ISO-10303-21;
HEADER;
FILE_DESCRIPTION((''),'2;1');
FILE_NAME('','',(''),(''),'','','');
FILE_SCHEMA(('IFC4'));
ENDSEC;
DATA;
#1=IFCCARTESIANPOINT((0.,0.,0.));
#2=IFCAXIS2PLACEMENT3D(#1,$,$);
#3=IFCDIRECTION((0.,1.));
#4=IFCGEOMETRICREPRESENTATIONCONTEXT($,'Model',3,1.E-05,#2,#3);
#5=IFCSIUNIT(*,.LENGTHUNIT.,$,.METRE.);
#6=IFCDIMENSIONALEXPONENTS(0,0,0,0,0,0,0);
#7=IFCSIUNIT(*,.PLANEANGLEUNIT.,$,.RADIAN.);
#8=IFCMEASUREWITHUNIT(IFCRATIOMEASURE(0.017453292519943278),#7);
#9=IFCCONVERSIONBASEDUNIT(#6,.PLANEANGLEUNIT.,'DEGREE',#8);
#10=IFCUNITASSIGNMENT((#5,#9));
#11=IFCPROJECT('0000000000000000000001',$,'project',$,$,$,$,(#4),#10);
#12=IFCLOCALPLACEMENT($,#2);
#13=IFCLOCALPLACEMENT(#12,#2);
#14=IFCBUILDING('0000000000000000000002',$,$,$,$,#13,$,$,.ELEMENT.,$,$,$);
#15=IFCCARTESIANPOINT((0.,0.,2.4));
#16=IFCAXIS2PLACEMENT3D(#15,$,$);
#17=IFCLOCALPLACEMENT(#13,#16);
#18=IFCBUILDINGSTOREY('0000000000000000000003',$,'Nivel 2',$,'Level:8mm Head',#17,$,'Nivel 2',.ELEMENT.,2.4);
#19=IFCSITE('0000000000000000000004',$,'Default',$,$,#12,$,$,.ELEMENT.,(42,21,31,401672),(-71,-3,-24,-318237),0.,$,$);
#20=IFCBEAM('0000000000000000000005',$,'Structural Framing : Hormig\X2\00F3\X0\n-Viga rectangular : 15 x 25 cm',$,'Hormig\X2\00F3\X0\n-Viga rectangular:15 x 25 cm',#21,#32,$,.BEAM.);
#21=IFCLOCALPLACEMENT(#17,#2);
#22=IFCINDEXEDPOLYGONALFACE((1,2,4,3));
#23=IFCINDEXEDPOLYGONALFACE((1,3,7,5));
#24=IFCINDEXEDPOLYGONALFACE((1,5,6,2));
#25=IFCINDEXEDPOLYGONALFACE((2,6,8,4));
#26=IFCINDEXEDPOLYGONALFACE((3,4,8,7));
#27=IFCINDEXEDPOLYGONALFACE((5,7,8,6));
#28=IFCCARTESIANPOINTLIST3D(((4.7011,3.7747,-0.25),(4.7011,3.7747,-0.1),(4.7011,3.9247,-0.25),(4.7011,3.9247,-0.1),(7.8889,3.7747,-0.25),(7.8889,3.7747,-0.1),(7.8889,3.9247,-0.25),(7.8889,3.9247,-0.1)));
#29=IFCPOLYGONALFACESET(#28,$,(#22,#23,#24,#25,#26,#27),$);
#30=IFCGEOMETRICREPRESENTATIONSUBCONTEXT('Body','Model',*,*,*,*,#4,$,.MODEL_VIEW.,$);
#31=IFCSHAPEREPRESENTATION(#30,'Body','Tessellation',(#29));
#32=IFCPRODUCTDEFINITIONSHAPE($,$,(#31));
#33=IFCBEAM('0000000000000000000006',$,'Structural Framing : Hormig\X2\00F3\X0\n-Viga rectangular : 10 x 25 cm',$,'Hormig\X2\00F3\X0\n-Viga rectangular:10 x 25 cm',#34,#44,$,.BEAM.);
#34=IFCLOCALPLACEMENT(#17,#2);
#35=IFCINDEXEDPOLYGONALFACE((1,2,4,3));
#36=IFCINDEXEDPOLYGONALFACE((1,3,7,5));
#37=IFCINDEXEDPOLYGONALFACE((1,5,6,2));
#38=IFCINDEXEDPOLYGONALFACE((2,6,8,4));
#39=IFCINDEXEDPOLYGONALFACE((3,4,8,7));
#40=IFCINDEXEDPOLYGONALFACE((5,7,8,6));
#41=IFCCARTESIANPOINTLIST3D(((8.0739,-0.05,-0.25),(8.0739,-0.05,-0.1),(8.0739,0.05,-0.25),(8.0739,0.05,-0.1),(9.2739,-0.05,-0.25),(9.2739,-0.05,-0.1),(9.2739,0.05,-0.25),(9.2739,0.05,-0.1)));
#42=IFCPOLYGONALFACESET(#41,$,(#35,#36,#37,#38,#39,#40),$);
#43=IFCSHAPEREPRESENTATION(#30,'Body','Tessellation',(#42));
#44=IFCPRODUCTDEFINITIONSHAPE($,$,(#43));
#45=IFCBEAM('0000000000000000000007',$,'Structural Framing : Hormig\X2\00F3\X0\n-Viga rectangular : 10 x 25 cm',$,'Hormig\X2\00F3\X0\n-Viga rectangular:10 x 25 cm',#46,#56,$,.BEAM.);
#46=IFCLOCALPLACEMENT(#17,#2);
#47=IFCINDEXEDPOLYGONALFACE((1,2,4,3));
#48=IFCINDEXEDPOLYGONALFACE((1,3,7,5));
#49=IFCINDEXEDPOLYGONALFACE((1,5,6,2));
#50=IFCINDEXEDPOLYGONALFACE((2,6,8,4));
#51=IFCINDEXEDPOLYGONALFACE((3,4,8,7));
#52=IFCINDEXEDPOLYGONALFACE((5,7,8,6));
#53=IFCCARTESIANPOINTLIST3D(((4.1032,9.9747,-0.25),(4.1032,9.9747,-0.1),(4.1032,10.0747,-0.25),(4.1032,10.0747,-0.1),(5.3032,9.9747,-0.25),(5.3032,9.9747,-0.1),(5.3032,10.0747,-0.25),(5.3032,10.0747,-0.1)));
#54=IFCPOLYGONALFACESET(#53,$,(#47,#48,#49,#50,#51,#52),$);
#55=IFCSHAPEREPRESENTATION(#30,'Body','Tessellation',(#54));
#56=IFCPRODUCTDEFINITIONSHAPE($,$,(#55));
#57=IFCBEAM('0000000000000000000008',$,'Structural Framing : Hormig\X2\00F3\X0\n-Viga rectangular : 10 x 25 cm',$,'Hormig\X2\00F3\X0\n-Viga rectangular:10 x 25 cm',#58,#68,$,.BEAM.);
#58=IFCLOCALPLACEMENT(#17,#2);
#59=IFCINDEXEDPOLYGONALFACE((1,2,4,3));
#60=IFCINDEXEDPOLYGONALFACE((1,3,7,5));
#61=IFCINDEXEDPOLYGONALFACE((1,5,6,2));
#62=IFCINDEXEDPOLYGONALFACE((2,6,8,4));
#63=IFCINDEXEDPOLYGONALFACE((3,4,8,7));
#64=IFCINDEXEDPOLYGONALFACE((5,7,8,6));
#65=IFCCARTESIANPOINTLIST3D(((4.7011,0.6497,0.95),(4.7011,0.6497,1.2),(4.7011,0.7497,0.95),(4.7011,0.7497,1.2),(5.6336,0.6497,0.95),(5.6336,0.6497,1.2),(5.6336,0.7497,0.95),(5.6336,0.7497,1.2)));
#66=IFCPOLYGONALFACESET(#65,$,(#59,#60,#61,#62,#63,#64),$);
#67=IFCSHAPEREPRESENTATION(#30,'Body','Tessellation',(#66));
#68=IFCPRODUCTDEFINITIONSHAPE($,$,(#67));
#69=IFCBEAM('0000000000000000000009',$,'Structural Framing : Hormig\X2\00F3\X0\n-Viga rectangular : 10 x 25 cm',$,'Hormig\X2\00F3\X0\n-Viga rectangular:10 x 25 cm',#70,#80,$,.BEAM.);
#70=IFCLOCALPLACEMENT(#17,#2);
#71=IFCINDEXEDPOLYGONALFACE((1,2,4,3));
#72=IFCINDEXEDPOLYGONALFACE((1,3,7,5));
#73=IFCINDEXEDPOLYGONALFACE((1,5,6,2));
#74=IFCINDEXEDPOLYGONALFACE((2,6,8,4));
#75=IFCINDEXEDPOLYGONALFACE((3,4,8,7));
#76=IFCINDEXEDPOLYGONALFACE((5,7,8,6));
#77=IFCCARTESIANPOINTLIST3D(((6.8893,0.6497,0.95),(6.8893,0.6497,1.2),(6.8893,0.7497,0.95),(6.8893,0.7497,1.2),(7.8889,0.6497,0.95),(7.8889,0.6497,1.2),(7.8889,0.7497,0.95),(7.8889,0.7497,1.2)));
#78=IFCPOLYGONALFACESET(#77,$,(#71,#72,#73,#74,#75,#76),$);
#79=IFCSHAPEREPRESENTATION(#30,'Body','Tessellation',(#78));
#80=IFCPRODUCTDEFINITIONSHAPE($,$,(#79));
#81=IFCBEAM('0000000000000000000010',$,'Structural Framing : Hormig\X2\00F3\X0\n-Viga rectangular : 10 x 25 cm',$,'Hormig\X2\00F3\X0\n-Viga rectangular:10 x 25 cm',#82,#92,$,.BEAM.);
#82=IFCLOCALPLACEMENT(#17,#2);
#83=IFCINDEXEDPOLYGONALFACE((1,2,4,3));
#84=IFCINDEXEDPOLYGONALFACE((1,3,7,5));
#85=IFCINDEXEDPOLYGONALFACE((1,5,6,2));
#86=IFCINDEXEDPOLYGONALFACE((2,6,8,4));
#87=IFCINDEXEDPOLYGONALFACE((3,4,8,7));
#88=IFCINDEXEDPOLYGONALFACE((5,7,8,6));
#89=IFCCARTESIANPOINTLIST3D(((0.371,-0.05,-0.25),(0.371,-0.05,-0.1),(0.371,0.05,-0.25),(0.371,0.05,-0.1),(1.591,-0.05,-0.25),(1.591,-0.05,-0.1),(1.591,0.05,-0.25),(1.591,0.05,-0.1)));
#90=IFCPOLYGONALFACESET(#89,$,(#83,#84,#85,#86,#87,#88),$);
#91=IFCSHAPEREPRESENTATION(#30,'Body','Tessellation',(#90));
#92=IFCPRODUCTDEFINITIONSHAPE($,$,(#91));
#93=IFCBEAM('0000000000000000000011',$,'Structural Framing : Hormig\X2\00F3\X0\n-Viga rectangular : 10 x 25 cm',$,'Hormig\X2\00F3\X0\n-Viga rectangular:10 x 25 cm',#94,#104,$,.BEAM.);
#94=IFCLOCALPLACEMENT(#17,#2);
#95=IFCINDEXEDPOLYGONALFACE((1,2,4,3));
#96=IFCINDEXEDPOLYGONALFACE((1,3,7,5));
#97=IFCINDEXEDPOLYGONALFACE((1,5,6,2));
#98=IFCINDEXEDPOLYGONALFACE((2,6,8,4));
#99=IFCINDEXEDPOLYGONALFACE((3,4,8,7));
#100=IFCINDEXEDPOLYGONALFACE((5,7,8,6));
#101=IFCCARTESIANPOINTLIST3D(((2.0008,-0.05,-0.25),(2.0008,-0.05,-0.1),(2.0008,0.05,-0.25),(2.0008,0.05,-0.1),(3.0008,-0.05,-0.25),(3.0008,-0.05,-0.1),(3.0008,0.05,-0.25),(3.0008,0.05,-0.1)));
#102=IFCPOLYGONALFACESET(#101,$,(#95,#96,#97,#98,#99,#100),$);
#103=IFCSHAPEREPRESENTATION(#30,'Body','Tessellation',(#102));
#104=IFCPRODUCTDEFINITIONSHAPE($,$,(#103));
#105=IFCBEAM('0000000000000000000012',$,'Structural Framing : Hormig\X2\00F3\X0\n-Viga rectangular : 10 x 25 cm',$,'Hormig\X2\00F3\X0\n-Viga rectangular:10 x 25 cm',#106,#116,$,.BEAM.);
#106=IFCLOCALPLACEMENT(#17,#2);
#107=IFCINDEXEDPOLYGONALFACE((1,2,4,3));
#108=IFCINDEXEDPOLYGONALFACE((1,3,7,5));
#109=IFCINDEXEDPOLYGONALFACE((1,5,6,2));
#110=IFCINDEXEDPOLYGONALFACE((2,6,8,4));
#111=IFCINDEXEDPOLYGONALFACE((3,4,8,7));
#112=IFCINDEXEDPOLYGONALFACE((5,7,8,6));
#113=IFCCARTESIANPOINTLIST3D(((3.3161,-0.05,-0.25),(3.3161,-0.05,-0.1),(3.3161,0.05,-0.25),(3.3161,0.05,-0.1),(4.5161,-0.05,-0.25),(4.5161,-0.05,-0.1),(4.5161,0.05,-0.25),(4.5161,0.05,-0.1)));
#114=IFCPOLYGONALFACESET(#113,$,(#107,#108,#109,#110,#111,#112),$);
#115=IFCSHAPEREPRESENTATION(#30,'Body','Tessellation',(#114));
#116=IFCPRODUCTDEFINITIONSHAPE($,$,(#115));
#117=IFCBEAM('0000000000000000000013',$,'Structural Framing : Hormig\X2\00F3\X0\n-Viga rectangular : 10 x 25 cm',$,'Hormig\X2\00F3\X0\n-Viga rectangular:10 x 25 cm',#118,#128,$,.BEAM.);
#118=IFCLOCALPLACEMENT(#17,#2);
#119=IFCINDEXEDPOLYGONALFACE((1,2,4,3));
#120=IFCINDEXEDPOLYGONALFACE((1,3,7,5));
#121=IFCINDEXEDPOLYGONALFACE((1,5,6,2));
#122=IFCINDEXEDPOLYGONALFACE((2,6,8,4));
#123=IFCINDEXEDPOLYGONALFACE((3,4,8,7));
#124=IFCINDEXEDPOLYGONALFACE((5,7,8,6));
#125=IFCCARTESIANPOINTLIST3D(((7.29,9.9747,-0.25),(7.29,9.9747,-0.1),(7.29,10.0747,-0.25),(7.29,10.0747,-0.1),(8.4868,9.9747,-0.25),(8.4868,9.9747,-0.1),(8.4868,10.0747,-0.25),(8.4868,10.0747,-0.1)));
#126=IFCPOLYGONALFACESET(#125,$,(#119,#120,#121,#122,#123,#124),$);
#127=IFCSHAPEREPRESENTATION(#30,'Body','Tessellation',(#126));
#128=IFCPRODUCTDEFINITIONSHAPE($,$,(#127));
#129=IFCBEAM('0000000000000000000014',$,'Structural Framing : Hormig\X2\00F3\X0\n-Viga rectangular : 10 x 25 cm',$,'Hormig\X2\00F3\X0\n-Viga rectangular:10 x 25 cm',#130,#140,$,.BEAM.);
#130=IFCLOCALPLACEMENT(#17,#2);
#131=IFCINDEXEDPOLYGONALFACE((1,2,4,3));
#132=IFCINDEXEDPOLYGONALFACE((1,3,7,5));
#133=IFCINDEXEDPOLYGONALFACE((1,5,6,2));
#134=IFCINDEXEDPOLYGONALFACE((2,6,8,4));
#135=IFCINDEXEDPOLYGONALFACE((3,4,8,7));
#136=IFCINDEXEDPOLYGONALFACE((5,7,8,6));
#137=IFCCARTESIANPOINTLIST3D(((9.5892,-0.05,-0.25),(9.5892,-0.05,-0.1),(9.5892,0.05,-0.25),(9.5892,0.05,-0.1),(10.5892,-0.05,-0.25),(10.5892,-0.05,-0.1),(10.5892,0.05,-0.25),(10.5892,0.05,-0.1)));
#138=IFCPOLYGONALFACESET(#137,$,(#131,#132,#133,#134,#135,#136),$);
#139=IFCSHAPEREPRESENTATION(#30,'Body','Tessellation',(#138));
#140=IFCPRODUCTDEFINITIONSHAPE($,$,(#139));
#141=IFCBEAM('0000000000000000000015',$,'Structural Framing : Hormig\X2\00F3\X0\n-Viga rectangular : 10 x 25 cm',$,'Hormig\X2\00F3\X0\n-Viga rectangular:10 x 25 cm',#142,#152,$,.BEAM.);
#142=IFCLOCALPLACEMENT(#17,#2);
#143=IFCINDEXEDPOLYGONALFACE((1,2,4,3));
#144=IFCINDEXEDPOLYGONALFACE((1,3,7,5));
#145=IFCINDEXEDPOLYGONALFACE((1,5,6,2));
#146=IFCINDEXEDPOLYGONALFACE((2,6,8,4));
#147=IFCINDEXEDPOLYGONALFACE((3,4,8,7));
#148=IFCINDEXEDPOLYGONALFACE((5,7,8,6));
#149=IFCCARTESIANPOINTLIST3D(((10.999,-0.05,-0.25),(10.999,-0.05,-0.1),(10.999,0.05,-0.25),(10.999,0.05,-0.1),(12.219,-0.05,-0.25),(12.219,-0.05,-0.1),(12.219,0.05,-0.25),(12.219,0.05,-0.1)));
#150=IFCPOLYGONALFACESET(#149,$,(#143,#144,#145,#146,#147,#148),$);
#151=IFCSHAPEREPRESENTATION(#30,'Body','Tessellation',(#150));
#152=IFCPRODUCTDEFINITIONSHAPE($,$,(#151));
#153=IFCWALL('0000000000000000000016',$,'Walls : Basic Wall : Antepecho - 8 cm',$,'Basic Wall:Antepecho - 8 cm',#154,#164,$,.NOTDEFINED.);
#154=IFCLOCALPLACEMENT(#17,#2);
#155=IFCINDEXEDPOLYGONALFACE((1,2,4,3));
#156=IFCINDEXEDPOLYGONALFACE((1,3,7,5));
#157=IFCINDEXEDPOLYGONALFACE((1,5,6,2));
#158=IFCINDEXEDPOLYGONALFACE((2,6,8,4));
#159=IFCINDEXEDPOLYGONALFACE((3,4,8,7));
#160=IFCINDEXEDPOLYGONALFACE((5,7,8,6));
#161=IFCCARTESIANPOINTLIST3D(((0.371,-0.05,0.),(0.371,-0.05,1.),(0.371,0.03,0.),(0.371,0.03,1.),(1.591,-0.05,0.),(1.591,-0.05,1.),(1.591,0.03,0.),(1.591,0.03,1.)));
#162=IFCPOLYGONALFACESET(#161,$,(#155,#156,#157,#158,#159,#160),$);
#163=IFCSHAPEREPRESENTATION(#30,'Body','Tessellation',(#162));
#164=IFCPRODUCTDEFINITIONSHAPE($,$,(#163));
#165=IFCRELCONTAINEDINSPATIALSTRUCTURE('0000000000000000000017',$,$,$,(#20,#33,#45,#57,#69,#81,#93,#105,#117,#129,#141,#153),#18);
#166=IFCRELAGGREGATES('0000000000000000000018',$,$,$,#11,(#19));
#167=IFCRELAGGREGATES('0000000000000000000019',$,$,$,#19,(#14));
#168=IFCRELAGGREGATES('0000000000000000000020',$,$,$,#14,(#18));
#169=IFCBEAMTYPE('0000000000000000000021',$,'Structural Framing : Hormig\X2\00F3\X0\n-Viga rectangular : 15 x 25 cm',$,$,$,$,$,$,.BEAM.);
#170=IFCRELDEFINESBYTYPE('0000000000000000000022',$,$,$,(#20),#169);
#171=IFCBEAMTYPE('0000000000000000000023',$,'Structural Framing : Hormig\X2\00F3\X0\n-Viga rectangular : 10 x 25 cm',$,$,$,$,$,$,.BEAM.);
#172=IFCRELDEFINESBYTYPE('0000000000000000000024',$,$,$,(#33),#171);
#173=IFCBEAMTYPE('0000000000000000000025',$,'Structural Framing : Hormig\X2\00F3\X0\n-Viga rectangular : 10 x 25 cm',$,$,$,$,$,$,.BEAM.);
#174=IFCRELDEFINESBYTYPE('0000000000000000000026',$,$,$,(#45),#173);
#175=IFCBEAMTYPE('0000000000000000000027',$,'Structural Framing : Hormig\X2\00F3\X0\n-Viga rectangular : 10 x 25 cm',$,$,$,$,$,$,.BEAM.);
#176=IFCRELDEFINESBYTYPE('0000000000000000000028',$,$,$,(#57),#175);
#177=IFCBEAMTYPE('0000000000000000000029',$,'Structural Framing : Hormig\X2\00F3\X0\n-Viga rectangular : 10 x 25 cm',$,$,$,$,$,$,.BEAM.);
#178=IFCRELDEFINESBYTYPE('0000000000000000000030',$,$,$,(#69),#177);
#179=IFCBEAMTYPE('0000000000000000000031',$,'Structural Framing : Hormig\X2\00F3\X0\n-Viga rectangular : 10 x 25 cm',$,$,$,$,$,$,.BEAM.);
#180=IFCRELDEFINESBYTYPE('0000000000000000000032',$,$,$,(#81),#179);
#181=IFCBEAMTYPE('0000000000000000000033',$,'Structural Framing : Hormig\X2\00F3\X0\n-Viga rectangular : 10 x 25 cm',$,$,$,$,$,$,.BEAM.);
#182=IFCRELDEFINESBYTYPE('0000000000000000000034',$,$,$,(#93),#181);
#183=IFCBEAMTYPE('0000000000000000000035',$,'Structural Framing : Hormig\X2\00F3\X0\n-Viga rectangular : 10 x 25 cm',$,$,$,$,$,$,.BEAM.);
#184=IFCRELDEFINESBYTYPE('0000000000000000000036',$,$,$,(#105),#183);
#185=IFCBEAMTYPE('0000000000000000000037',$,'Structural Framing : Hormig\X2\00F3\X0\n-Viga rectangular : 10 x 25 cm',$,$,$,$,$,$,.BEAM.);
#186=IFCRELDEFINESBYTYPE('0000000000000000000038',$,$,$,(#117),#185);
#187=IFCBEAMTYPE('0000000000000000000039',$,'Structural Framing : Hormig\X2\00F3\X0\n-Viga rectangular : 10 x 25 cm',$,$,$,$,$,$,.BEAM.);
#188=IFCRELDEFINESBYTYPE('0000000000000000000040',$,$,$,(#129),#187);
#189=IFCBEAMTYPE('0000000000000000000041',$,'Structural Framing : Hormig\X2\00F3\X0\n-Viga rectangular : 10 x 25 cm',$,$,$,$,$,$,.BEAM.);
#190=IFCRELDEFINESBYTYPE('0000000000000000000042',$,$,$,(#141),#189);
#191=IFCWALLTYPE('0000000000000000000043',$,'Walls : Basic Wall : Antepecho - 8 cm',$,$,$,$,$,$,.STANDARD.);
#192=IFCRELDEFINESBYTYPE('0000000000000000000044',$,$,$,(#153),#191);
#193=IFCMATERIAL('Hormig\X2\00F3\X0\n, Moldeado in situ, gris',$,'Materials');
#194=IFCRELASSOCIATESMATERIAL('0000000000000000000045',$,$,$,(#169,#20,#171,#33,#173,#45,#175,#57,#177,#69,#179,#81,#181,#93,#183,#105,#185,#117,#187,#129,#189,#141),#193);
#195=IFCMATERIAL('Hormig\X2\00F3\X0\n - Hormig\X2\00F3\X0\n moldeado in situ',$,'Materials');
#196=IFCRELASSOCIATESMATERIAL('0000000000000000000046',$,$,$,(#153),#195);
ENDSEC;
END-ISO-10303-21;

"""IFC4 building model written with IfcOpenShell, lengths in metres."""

from ifc_helpers import new_model, entity, si_unit, converted_unit, direction, frame, origin, place, context, subcontext, project, spatial, indexed_curve, outline, extrude, source, transform, mapped, material, type_object, type_shapes, element, save


model = new_model("IFC4")

# Units and contexts
model_context = context("Model", 3, precision=1e-05, world=origin(), true_north=direction((0.0, 1.0)))
body_context = subcontext(model_context, "Body", "Model", "MODEL_VIEW")
ifc_project = project(units=[si_unit("LENGTHUNIT", "METRE"), converted_unit("PLANEANGLEUNIT", "DEGREE", entity("IfcRatioMeasure", 0.017453292519943278), si_unit("PLANEANGLEUNIT", "RADIAN"), dimensions=[0, 0, 0, 0, 0, 0, 0])], contexts=[model_context])

# Site, building, storey
site_placement = place(None, origin())
site = spatial("IfcSite", under=ifc_project, at=site_placement, Name="Default", CompositionType="ELEMENT", RefLatitude=(42, 21, 31, 401672), RefLongitude=(-71, -3, -24, -318237), RefElevation=0.0)
building_placement = place(site_placement, origin())
building = spatial("IfcBuilding", under=site, at=building_placement, CompositionType="ELEMENT")
storey_placement = place(building_placement, frame((0.0, 0.0, 2.4)))
storey = spatial("IfcBuildingStorey", under=building, at=storey_placement, Name="Nivel 2", ObjectType="Level:8mm Head", LongName="Nivel 2", CompositionType="ELEMENT", Elevation=2.4)

# Beams
ifc_material_1 = material(Name="Hormigón, Moldeado in situ, gris", Category="Materials")
beam_type_1 = type_object("IfcBeamType", Name="Structural Framing : Hormigón-Viga rectangular : 15 x 25 cm", PredefinedType="BEAM", material=ifc_material_1)
shared_shape_1 = source(origin(), body_context, "Body", "SweptSolid", [
    extrude(outline(indexed_curve([(-0.075, -0.075), (0.075, -0.075), (0.075, 0.075), (-0.075, 0.075), (-0.075, -0.075)], self_intersect=False)), frame((4.7011, 3.8497, 2.225), z_axis=(1.0, 0.0, 0.0), x_axis=(0.0, 0.0, -1.0)), (0.0, 0.0, 1.0), 3.1878),
])
type_shapes(beam_type_1, [shared_shape_1])
beam_1_placement = place(storey_placement, frame((0.0, 0.0, -2.4)))
element("IfcBeam", 1, at=beam_1_placement, inside=storey, type_object=beam_type_1, material=ifc_material_1, Name="Structural Framing : Hormigón-Viga rectangular : 15 x 25 cm", ObjectType="Hormigón-Viga rectangular:15 x 25 cm", PredefinedType="BEAM", context=body_context, shape_type="MappedRepresentation", body=[
    mapped(shared_shape_1, transform((0.0, 0.0, 0.0), scale=1.0)),
])
beam_type_2 = type_object("IfcBeamType", Name="Structural Framing : Hormigón-Viga rectangular : 10 x 25 cm", PredefinedType="BEAM", material=ifc_material_1)
shared_shape_2 = source(origin(), body_context, "Body", "SweptSolid", [
    extrude(outline(indexed_curve([(-0.075, -0.05), (0.075, -0.05), (0.075, 0.05), (-0.075, 0.05), (-0.075, -0.05)], self_intersect=False)), frame((8.0739, 0.0, 2.225), z_axis=(1.0, 0.0, 0.0), x_axis=(0.0, 0.0, -1.0)), (0.0, 0.0, 1.0), 1.2),
])
type_shapes(beam_type_2, [shared_shape_2])
beam_2_placement = place(storey_placement, frame((0.0, 0.0, -2.4)))
element("IfcBeam", 2, at=beam_2_placement, inside=storey, type_object=beam_type_2, material=ifc_material_1, Name="Structural Framing : Hormigón-Viga rectangular : 10 x 25 cm", ObjectType="Hormigón-Viga rectangular:10 x 25 cm", PredefinedType="BEAM", context=body_context, shape_type="MappedRepresentation", body=[
    mapped(shared_shape_2, transform((0.0, 0.0, 0.0), scale=1.0)),
])
beam_type_3 = type_object("IfcBeamType", Name="Structural Framing : Hormigón-Viga rectangular : 10 x 25 cm", PredefinedType="BEAM", material=ifc_material_1)
shared_shape_3 = source(origin(), body_context, "Body", "SweptSolid", [
    extrude(outline(indexed_curve([(-0.075, -0.05), (0.075, -0.05), (0.075, 0.05), (-0.075, 0.05), (-0.075, -0.05)], self_intersect=False)), frame((5.3032, 10.0247, 2.225), z_axis=(-1.0, 0.0, 0.0), x_axis=(0.0, 0.0, -1.0)), (0.0, 0.0, 1.0), 1.2),
])
type_shapes(beam_type_3, [shared_shape_3])
beam_3_placement = place(storey_placement, frame((0.0, 0.0, -2.4)))
element("IfcBeam", 3, at=beam_3_placement, inside=storey, type_object=beam_type_3, material=ifc_material_1, Name="Structural Framing : Hormigón-Viga rectangular : 10 x 25 cm", ObjectType="Hormigón-Viga rectangular:10 x 25 cm", PredefinedType="BEAM", context=body_context, shape_type="MappedRepresentation", body=[
    mapped(shared_shape_3, transform((0.0, 0.0, 0.0), scale=1.0)),
])
beam_type_4 = type_object("IfcBeamType", Name="Structural Framing : Hormigón-Viga rectangular : 10 x 25 cm", PredefinedType="BEAM", material=ifc_material_1)
shared_shape_4 = source(origin(), body_context, "Body", "SweptSolid", [
    extrude(outline(indexed_curve([(-0.125, -0.05), (0.125, -0.05), (0.125, 0.05), (-0.125, 0.05), (-0.125, -0.05)], self_intersect=False)), frame((5.6336, 0.6997, 3.475), z_axis=(-1.0, 0.0, 0.0), x_axis=(0.0, 0.0, -1.0)), (0.0, 0.0, 1.0), 0.9325),
])
type_shapes(beam_type_4, [shared_shape_4])
beam_4_placement = place(storey_placement, frame((0.0, 0.0, -2.4)))
element("IfcBeam", 4, at=beam_4_placement, inside=storey, type_object=beam_type_4, material=ifc_material_1, Name="Structural Framing : Hormigón-Viga rectangular : 10 x 25 cm", ObjectType="Hormigón-Viga rectangular:10 x 25 cm", PredefinedType="BEAM", context=body_context, shape_type="MappedRepresentation", body=[
    mapped(shared_shape_4, transform((0.0, 0.0, 0.0), scale=1.0)),
])
beam_type_5 = type_object("IfcBeamType", Name="Structural Framing : Hormigón-Viga rectangular : 10 x 25 cm", PredefinedType="BEAM", material=ifc_material_1)
shared_shape_5 = source(origin(), body_context, "Body", "SweptSolid", [
    extrude(outline(indexed_curve([(-0.125, -0.05), (0.125, -0.05), (0.125, 0.05), (-0.125, 0.05), (-0.125, -0.05)], self_intersect=False)), frame((7.8889, 0.6997, 3.475), z_axis=(-1.0, 0.0, 0.0), x_axis=(0.0, 0.0, -1.0)), (0.0, 0.0, 1.0), 0.9996),
])
type_shapes(beam_type_5, [shared_shape_5])
beam_5_placement = place(storey_placement, frame((0.0, 0.0, -2.4)))
element("IfcBeam", 5, at=beam_5_placement, inside=storey, type_object=beam_type_5, material=ifc_material_1, Name="Structural Framing : Hormigón-Viga rectangular : 10 x 25 cm", ObjectType="Hormigón-Viga rectangular:10 x 25 cm", PredefinedType="BEAM", context=body_context, shape_type="MappedRepresentation", body=[
    mapped(shared_shape_5, transform((0.0, 0.0, 0.0), scale=1.0)),
])
beam_type_6 = type_object("IfcBeamType", Name="Structural Framing : Hormigón-Viga rectangular : 10 x 25 cm", PredefinedType="BEAM", material=ifc_material_1)
shared_shape_6 = source(origin(), body_context, "Body", "SweptSolid", [
    extrude(outline(indexed_curve([(-0.075, -0.05), (0.075, -0.05), (0.075, 0.05), (-0.075, 0.05), (-0.075, -0.05)], self_intersect=False)), frame((0.371, 0.0, 2.225), z_axis=(1.0, 0.0, 0.0), x_axis=(0.0, 0.0, -1.0)), (0.0, 0.0, 1.0), 1.22),
])
type_shapes(beam_type_6, [shared_shape_6])
beam_6_placement = place(storey_placement, frame((0.0, 0.0, -2.4)))
element("IfcBeam", 6, at=beam_6_placement, inside=storey, type_object=beam_type_6, material=ifc_material_1, Name="Structural Framing : Hormigón-Viga rectangular : 10 x 25 cm", ObjectType="Hormigón-Viga rectangular:10 x 25 cm", PredefinedType="BEAM", context=body_context, shape_type="MappedRepresentation", body=[
    mapped(shared_shape_6, transform((0.0, 0.0, 0.0), scale=1.0)),
])
beam_type_7 = type_object("IfcBeamType", Name="Structural Framing : Hormigón-Viga rectangular : 10 x 25 cm", PredefinedType="BEAM", material=ifc_material_1)
shared_shape_7 = source(origin(), body_context, "Body", "SweptSolid", [
    extrude(outline(indexed_curve([(-0.075, -0.05), (0.075, -0.05), (0.075, 0.05), (-0.075, 0.05), (-0.075, -0.05)], self_intersect=False)), frame((2.0008, 0.0, 2.225), z_axis=(1.0, 0.0, 0.0), x_axis=(0.0, 0.0, -1.0)), (0.0, 0.0, 1.0), 1.0),
])
type_shapes(beam_type_7, [shared_shape_7])
beam_7_placement = place(storey_placement, frame((0.0, 0.0, -2.4)))
element("IfcBeam", 7, at=beam_7_placement, inside=storey, type_object=beam_type_7, material=ifc_material_1, Name="Structural Framing : Hormigón-Viga rectangular : 10 x 25 cm", ObjectType="Hormigón-Viga rectangular:10 x 25 cm", PredefinedType="BEAM", context=body_context, shape_type="MappedRepresentation", body=[
    mapped(shared_shape_7, transform((0.0, 0.0, 0.0), scale=1.0)),
])
beam_type_8 = type_object("IfcBeamType", Name="Structural Framing : Hormigón-Viga rectangular : 10 x 25 cm", PredefinedType="BEAM", material=ifc_material_1)
shared_shape_8 = source(origin(), body_context, "Body", "SweptSolid", [
    extrude(outline(indexed_curve([(-0.075, -0.05), (0.075, -0.05), (0.075, 0.05), (-0.075, 0.05), (-0.075, -0.05)], self_intersect=False)), frame((3.3161, 0.0, 2.225), z_axis=(1.0, 0.0, 0.0), x_axis=(0.0, 0.0, -1.0)), (0.0, 0.0, 1.0), 1.2),
])
type_shapes(beam_type_8, [shared_shape_8])
beam_8_placement = place(storey_placement, frame((0.0, 0.0, -2.4)))
element("IfcBeam", 8, at=beam_8_placement, inside=storey, type_object=beam_type_8, material=ifc_material_1, Name="Structural Framing : Hormigón-Viga rectangular : 10 x 25 cm", ObjectType="Hormigón-Viga rectangular:10 x 25 cm", PredefinedType="BEAM", context=body_context, shape_type="MappedRepresentation", body=[
    mapped(shared_shape_8, transform((0.0, 0.0, 0.0), scale=1.0)),
])
beam_type_9 = type_object("IfcBeamType", Name="Structural Framing : Hormigón-Viga rectangular : 10 x 25 cm", PredefinedType="BEAM", material=ifc_material_1)
shared_shape_9 = source(origin(), body_context, "Body", "SweptSolid", [
    extrude(outline(indexed_curve([(-0.075, -0.05), (0.075, -0.05), (0.075, 0.05), (-0.075, 0.05), (-0.075, -0.05)], self_intersect=False)), frame((7.29, 10.0247, 2.225), z_axis=(1.0, 0.0, 0.0), x_axis=(0.0, 0.0, -1.0)), (0.0, 0.0, 1.0), 1.1968),
])
type_shapes(beam_type_9, [shared_shape_9])
beam_9_placement = place(storey_placement, frame((0.0, 0.0, -2.4)))
element("IfcBeam", 9, at=beam_9_placement, inside=storey, type_object=beam_type_9, material=ifc_material_1, Name="Structural Framing : Hormigón-Viga rectangular : 10 x 25 cm", ObjectType="Hormigón-Viga rectangular:10 x 25 cm", PredefinedType="BEAM", context=body_context, shape_type="MappedRepresentation", body=[
    mapped(shared_shape_9, transform((0.0, 0.0, 0.0), scale=1.0)),
])
beam_type_10 = type_object("IfcBeamType", Name="Structural Framing : Hormigón-Viga rectangular : 10 x 25 cm", PredefinedType="BEAM", material=ifc_material_1)
shared_shape_10 = source(origin(), body_context, "Body", "SweptSolid", [
    extrude(outline(indexed_curve([(-0.075, -0.05), (0.075, -0.05), (0.075, 0.05), (-0.075, 0.05), (-0.075, -0.05)], self_intersect=False)), frame((9.5892, 0.0, 2.225), z_axis=(1.0, 0.0, 0.0), x_axis=(0.0, 0.0, -1.0)), (0.0, 0.0, 1.0), 1.0),
])
type_shapes(beam_type_10, [shared_shape_10])
beam_10_placement = place(storey_placement, frame((0.0, 0.0, -2.4)))
element("IfcBeam", 10, at=beam_10_placement, inside=storey, type_object=beam_type_10, material=ifc_material_1, Name="Structural Framing : Hormigón-Viga rectangular : 10 x 25 cm", ObjectType="Hormigón-Viga rectangular:10 x 25 cm", PredefinedType="BEAM", context=body_context, shape_type="MappedRepresentation", body=[
    mapped(shared_shape_10, transform((0.0, 0.0, 0.0), scale=1.0)),
])
beam_type_11 = type_object("IfcBeamType", Name="Structural Framing : Hormigón-Viga rectangular : 10 x 25 cm", PredefinedType="BEAM", material=ifc_material_1)
shared_shape_11 = source(origin(), body_context, "Body", "SweptSolid", [
    extrude(outline(indexed_curve([(-0.075, -0.05), (0.075, -0.05), (0.075, 0.05), (-0.075, 0.05), (-0.075, -0.05)], self_intersect=False)), frame((12.219, 0.0, 2.225), z_axis=(-1.0, 0.0, 0.0), x_axis=(0.0, 0.0, -1.0)), (0.0, 0.0, 1.0), 1.22),
])
type_shapes(beam_type_11, [shared_shape_11])
beam_11_placement = place(storey_placement, frame((0.0, 0.0, -2.4)))
element("IfcBeam", 11, at=beam_11_placement, inside=storey, type_object=beam_type_11, material=ifc_material_1, Name="Structural Framing : Hormigón-Viga rectangular : 10 x 25 cm", ObjectType="Hormigón-Viga rectangular:10 x 25 cm", PredefinedType="BEAM", context=body_context, shape_type="MappedRepresentation", body=[
    mapped(shared_shape_11, transform((0.0, 0.0, 0.0), scale=1.0)),
])

# Shared definitions
ifc_material_2 = material(Name="Hormigón - Hormigón moldeado in situ", Category="Materials")

# Wall
wall_type = type_object("IfcWallType", Name="Walls : Basic Wall : Antepecho - 8 cm", PredefinedType="STANDARD")
wall_1_placement = place(storey_placement, frame((0.371, -0.01, 0.0)))
element("IfcWall", 12, at=wall_1_placement, inside=storey, type_object=wall_type, material=ifc_material_2, Name="Walls : Basic Wall : Antepecho - 8 cm", ObjectType="Basic Wall:Antepecho - 8 cm", PredefinedType="NOTDEFINED", context=body_context, shape_type="SweptSolid", body=[
    extrude(outline(indexed_curve([(1.22, 0.04), (0.0, 0.04), (0.0, -0.04), (1.22, -0.04), (1.22, 0.04)], self_intersect=False)), origin(), (0.0, 0.0, 1.0), 1.0),
])

save(model, "model.ifc")
